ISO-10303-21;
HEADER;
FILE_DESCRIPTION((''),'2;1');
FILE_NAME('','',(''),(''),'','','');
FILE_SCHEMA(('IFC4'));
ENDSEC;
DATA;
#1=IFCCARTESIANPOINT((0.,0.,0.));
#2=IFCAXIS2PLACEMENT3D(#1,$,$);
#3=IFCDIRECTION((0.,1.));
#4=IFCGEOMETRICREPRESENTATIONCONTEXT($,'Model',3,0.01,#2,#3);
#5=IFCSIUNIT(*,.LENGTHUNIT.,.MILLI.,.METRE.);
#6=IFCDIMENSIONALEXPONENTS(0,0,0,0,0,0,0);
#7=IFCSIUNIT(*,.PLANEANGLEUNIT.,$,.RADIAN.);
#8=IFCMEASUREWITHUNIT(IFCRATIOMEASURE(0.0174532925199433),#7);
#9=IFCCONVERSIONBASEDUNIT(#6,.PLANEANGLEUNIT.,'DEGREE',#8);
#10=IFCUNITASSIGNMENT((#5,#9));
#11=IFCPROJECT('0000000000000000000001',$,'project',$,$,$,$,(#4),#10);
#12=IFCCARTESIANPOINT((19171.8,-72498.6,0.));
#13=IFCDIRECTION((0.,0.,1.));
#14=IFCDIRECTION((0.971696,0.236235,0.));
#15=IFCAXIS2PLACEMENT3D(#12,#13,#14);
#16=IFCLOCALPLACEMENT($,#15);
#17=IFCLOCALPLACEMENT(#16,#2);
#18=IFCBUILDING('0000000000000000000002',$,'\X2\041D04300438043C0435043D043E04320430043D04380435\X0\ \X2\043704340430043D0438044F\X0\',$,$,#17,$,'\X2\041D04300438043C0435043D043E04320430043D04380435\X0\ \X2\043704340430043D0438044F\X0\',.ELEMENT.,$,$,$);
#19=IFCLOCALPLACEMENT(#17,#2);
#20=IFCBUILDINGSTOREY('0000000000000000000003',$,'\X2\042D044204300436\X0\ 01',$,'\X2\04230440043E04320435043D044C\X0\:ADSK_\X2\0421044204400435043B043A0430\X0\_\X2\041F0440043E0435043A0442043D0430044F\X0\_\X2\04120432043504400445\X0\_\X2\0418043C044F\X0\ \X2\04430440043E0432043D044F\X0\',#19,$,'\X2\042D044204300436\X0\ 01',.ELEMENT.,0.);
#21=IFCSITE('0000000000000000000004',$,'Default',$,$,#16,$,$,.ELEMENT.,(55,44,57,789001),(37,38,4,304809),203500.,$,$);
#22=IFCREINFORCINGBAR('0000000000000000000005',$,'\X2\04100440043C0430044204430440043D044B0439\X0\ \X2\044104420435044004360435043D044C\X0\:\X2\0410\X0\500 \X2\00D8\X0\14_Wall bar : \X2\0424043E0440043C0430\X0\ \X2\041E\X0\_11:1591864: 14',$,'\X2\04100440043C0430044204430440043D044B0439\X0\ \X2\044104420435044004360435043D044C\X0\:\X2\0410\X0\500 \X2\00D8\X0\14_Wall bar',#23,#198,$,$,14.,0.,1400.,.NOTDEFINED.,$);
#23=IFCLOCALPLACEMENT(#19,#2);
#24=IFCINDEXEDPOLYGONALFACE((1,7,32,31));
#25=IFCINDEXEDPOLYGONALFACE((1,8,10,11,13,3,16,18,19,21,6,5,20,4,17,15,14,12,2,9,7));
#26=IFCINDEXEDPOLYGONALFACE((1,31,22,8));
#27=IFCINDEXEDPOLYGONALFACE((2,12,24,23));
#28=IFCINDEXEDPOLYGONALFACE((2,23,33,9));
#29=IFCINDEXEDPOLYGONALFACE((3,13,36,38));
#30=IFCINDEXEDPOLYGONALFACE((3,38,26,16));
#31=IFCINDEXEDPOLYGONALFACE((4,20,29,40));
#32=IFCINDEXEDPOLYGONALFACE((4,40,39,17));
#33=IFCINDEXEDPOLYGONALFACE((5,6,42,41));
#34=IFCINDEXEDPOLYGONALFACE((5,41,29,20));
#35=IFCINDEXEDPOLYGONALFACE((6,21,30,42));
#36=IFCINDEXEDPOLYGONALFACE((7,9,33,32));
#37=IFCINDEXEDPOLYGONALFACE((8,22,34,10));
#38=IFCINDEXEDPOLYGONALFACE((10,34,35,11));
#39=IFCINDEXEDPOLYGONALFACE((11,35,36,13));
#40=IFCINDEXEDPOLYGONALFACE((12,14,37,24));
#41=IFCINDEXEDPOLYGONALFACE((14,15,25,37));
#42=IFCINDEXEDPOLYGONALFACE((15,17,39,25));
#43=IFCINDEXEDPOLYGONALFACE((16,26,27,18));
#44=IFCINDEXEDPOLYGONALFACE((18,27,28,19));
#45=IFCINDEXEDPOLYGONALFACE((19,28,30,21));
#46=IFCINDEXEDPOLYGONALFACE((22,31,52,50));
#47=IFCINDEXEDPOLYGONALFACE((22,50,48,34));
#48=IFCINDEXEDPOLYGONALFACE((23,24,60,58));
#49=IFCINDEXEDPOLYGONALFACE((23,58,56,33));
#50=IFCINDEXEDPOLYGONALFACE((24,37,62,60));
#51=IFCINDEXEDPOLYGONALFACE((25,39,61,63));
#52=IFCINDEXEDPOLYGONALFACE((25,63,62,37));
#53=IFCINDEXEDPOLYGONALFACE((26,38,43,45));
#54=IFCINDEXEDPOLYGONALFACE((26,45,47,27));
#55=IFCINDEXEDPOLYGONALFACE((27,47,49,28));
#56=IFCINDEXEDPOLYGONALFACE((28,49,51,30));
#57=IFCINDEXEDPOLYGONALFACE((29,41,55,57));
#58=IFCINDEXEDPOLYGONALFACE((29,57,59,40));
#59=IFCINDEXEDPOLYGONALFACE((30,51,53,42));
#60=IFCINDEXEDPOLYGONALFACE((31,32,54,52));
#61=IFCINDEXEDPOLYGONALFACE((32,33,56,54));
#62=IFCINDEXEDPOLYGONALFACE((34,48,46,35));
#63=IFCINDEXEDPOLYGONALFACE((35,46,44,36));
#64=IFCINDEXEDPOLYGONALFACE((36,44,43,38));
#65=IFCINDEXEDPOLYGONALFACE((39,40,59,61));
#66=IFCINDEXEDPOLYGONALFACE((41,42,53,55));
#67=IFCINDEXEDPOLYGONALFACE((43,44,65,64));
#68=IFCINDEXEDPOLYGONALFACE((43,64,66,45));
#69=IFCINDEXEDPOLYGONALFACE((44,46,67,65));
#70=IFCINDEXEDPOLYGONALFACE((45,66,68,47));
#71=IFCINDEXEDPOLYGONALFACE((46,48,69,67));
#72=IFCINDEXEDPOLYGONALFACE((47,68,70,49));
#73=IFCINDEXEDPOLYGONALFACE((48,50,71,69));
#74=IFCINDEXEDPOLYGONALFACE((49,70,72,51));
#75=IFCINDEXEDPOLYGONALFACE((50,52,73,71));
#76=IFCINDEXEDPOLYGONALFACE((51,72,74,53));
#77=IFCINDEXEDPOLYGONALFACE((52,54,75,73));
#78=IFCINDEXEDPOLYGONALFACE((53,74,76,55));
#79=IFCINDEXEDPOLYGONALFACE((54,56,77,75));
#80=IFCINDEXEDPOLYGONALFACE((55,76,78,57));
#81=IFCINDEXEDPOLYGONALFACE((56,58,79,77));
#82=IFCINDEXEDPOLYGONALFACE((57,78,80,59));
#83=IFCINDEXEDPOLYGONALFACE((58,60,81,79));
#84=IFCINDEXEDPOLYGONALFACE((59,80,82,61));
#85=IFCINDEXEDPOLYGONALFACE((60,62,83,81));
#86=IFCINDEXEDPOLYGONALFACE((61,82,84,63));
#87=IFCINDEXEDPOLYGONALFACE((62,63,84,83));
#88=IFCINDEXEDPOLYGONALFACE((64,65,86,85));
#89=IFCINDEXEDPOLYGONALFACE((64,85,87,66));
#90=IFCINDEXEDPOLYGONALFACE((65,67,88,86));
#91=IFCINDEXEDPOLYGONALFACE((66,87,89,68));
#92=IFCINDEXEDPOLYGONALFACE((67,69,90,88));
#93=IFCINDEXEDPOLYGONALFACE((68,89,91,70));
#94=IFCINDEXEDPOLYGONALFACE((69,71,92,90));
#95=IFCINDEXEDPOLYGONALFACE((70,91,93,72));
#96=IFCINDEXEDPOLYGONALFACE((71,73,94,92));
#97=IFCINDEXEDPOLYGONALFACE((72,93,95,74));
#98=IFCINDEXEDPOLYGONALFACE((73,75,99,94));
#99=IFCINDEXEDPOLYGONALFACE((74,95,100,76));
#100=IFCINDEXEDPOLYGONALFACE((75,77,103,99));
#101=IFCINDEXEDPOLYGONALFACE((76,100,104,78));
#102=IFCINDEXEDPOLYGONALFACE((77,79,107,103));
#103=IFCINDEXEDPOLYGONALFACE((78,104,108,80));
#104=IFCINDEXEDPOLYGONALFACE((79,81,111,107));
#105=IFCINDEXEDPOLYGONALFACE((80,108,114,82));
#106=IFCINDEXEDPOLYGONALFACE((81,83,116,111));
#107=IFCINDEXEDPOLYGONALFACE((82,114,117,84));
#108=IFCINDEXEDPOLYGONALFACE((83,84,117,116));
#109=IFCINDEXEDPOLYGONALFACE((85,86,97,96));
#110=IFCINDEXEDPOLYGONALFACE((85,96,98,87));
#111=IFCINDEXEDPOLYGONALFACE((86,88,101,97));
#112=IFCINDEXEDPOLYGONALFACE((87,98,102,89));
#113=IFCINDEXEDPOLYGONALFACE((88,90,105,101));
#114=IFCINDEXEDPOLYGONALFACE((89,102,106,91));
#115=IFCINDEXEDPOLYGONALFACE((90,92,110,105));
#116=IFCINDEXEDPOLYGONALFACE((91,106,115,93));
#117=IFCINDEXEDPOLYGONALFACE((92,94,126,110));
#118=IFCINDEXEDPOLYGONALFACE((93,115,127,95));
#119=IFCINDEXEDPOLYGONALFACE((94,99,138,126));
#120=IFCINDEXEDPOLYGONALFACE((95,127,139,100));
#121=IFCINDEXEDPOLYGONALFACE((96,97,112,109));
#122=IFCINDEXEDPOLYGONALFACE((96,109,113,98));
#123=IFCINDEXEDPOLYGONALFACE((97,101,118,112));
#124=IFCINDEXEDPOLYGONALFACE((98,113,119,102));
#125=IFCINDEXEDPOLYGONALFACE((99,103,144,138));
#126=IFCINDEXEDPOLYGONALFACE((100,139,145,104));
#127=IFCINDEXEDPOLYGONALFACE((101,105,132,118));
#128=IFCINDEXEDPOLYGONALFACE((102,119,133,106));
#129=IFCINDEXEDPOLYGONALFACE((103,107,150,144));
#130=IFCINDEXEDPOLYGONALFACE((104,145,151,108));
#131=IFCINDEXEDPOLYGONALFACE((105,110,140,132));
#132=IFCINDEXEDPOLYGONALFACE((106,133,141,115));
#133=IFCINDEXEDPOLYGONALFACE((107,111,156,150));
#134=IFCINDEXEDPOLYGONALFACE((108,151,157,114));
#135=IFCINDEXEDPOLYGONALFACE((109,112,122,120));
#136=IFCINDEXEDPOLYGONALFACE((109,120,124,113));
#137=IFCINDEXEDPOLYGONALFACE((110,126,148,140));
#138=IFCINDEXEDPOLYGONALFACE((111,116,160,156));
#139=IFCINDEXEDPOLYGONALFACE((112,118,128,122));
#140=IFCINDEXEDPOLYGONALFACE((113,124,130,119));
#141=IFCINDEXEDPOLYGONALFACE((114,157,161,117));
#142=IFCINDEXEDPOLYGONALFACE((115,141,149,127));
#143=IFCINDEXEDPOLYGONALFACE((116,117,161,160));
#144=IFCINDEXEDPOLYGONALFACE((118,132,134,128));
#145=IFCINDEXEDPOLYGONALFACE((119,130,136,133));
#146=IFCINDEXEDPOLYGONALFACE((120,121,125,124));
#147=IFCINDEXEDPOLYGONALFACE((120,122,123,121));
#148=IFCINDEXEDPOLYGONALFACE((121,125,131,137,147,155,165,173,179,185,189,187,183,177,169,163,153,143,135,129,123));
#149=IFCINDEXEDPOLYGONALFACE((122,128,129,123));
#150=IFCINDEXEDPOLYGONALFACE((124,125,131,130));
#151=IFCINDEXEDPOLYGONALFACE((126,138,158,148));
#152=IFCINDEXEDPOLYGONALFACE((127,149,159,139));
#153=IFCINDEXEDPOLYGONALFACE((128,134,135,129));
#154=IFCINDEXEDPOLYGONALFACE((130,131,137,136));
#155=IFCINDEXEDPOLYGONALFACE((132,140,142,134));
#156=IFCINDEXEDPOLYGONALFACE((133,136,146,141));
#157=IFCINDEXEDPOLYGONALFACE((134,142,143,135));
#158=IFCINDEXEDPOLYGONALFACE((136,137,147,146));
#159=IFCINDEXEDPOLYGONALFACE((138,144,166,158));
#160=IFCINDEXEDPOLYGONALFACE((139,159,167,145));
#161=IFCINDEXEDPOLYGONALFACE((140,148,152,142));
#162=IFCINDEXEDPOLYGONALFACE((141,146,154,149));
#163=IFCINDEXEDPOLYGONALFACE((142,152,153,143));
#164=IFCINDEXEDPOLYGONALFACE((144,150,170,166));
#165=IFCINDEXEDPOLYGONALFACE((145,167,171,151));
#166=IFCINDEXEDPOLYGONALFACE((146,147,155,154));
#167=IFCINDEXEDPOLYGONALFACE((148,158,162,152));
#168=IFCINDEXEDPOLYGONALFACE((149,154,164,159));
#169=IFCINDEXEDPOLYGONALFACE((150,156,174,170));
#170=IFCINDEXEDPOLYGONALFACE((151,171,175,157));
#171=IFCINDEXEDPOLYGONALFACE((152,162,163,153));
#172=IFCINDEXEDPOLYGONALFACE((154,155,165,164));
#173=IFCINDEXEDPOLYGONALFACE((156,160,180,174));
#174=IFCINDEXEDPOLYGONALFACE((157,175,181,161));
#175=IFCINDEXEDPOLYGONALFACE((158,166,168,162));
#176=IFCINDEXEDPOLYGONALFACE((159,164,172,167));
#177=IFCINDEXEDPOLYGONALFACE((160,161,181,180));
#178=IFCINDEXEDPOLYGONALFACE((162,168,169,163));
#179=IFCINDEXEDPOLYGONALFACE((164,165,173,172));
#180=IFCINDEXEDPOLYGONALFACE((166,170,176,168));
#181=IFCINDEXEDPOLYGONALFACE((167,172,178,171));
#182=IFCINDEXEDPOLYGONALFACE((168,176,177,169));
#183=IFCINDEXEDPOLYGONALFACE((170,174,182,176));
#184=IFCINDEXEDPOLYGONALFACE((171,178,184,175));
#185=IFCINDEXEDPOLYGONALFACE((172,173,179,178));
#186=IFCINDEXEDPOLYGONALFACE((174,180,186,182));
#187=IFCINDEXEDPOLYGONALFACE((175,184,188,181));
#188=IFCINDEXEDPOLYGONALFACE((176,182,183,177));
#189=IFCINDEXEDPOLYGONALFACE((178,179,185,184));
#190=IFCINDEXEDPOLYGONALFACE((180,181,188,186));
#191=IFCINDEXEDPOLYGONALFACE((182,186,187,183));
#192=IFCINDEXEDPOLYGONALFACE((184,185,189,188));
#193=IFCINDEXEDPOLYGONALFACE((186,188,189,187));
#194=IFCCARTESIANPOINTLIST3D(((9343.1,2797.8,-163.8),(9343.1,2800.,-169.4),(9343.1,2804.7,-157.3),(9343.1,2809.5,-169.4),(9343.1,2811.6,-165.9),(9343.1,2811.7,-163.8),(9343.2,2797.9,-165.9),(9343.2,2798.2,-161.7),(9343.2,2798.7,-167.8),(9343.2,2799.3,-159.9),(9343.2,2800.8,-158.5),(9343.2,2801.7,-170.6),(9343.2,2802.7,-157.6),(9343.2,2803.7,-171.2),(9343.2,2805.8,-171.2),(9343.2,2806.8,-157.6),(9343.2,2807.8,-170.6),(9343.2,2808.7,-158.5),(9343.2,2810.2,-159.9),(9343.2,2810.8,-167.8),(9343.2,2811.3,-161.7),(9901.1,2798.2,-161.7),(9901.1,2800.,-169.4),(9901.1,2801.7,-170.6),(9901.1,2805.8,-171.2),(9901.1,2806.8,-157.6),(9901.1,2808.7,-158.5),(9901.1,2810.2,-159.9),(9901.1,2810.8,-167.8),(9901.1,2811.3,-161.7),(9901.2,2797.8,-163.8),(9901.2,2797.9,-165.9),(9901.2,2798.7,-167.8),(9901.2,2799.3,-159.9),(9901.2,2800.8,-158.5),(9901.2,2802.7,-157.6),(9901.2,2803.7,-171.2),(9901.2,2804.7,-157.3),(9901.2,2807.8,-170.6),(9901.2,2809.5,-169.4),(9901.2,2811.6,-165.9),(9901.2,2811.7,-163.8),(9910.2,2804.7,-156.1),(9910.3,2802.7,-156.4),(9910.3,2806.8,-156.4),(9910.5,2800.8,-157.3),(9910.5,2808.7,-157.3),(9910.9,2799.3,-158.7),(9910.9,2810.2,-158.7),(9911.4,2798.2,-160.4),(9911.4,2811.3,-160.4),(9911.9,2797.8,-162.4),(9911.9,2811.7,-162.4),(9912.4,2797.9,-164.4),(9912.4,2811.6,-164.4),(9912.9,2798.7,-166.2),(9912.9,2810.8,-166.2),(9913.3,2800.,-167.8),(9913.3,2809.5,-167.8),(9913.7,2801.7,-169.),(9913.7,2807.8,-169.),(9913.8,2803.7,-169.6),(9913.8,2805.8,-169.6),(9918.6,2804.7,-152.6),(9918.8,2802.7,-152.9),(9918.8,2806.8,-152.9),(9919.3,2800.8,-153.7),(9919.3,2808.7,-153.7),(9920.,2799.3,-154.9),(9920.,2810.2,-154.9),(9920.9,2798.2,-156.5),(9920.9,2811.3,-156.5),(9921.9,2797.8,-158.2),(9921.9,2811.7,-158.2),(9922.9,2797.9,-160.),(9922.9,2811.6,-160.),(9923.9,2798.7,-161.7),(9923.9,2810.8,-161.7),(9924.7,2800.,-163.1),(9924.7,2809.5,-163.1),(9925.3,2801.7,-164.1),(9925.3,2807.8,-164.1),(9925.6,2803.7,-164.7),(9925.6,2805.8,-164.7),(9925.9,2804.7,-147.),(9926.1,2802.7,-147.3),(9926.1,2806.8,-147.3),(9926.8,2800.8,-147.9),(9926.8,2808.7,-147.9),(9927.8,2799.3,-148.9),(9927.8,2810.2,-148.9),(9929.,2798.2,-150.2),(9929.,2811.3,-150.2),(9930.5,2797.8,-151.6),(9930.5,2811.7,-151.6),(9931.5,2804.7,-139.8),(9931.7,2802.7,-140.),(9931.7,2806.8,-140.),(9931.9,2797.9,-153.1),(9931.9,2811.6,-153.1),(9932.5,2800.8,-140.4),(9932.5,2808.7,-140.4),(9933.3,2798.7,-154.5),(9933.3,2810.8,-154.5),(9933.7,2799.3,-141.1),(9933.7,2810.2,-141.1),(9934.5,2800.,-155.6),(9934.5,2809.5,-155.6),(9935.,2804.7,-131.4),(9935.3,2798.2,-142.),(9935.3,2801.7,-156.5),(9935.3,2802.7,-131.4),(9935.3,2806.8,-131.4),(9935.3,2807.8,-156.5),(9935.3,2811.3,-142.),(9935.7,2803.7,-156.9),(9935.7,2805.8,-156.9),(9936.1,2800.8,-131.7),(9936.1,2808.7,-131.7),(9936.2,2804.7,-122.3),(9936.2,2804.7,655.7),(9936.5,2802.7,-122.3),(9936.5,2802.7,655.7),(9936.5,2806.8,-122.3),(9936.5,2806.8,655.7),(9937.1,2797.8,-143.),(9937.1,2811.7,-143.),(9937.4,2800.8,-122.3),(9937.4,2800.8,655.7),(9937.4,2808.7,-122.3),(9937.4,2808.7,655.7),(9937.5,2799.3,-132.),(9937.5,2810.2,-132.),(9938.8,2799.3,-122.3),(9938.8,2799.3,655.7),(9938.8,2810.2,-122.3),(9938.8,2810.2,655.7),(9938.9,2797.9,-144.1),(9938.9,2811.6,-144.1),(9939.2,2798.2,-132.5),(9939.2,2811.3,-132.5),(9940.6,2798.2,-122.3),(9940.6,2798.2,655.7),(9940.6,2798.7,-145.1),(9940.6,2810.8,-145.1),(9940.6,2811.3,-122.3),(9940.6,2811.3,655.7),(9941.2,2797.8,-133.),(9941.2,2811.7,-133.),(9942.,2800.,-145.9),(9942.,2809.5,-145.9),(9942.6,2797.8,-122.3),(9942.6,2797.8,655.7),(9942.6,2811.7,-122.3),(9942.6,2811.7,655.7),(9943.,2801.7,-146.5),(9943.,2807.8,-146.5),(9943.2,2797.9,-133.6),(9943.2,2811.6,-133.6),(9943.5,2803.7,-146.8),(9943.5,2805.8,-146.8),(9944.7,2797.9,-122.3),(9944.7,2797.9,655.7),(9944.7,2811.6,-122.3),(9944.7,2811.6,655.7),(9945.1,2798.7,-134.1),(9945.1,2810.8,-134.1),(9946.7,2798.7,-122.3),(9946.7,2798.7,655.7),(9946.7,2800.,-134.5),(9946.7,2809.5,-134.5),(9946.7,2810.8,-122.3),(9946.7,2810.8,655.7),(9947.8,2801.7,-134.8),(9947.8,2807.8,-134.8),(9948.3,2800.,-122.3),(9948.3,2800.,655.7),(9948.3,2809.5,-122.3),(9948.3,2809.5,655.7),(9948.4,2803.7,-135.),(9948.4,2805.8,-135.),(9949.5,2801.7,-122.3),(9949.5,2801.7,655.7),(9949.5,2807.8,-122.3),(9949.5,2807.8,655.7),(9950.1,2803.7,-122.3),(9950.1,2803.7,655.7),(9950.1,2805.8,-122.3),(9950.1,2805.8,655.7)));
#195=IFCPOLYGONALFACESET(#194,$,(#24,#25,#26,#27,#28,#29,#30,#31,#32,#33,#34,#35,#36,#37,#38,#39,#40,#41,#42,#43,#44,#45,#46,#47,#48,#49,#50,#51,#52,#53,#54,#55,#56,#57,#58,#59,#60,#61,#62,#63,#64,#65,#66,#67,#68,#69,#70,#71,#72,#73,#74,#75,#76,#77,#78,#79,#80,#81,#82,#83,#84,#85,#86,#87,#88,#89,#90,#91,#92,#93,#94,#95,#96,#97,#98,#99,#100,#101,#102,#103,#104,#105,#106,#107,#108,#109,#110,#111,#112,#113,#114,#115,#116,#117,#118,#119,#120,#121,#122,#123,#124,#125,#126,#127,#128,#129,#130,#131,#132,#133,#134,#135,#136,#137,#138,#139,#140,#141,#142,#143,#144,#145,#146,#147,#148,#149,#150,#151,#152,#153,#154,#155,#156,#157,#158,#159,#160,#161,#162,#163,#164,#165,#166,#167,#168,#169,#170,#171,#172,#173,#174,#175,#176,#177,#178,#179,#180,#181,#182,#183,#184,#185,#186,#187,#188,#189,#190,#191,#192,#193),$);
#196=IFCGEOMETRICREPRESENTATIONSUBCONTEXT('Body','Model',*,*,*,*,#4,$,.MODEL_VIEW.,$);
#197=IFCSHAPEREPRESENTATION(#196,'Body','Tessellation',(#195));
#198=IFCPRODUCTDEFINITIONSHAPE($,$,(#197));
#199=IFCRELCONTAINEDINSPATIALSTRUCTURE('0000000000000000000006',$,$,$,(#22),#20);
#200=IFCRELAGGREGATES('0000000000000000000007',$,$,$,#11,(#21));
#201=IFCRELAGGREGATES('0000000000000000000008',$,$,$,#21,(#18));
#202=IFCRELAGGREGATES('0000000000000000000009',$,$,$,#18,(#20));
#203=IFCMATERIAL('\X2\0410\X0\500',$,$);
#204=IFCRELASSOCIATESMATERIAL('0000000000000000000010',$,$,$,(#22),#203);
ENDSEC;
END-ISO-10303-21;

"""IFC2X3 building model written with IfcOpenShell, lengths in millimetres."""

from ifc_helpers import new_model, entity, si_unit, converted_unit, direction, frame, origin, place, context, subcontext, project, spatial, material, element, save


model = new_model("IFC2X3")

# Units and contexts
model_context = context("Model", 3, precision=0.01, world=origin(), true_north=direction((0.0, 1.0)))
body_context = subcontext(model_context, "Body", "Model", "MODEL_VIEW")
ifc_project = project(units=[si_unit("LENGTHUNIT", "METRE", prefix="MILLI"), converted_unit("PLANEANGLEUNIT", "DEGREE", entity("IfcRatioMeasure", 0.0174532925199433), si_unit("PLANEANGLEUNIT", "RADIAN"), dimensions=[0, 0, 0, 0, 0, 0, 0])], contexts=[model_context])

# Site, building, storey
site_placement = place(None, frame((19171.8, -72498.6, 0.0), z_axis=(0.0, 0.0, 1.0), x_axis=(0.971696, 0.236235, 0.0)))
site = spatial("IfcSite", under=ifc_project, at=site_placement, Name="Default", CompositionType="ELEMENT", RefLatitude=(55, 44, 57, 789001), RefLongitude=(37, 38, 4, 304809), RefElevation=203500.0)
building_placement = place(site_placement, origin())
building = spatial("IfcBuilding", under=site, at=building_placement, Name="Наименование здания", LongName="Наименование здания", CompositionType="ELEMENT")
storey_placement = place(building_placement, origin())
storey = spatial("IfcBuildingStorey", under=building, at=storey_placement, Name="Этаж 01", ObjectType="Уровень:ADSK_Стрелка_Проектная_Вверх_Имя уровня", LongName="Этаж 01", CompositionType="ELEMENT", Elevation=0.0)

# Reinforcing bar
ifc_material = material(Name="А500")
placement = place(storey_placement, origin())
element("IfcReinforcingBar", 1, at=placement, inside=storey, material=ifc_material, Name="Арматурный стержень:А500 Ø14_Wall bar : Форма О_11:1591864: 14", ObjectType="Арматурный стержень:А500 Ø14_Wall bar", BarLength=1400.0, BarRole="NOTDEFINED", CrossSectionArea=0.0, NominalDiameter=14.0, context=body_context, shape_type="AdvancedSweptSolid", body=[
    entity("IfcSweptDiskSolid", entity("IfcCompositeCurve", [entity("IfcCompositeCurveSegment", "CONTINUOUS", True, entity("IfcPolyline", [entity("IfcCartesianPoint", [9943.1, 2804.7, 655.7]), entity("IfcCartesianPoint", [9943.1, 2804.7, -122.3])])), entity("IfcCompositeCurveSegment", "CONTINUOUS", True, entity("IfcTrimmedCurve", entity("IfcCircle", entity("IfcAxis2Placement3D", entity("IfcCartesianPoint", [9901.1, 2804.7, -122.3]), entity("IfcDirection", [0.0, 1.0, 0.0]), entity("IfcDirection", [0.0, 0.0, -1.0])), 42.0), [entity("IfcParameterValue", 270.0)], [entity("IfcParameterValue", 360.0)], True, "PARAMETER")), entity("IfcCompositeCurveSegment", "CONTINUOUS", True, entity("IfcPolyline", [entity("IfcCartesianPoint", [9901.1, 2804.7, -164.3]), entity("IfcCartesianPoint", [9343.1, 2804.7, -164.3])]))], False), 7.0, None, 0.0, 92.0),
])

save(model, "model.ifc")
